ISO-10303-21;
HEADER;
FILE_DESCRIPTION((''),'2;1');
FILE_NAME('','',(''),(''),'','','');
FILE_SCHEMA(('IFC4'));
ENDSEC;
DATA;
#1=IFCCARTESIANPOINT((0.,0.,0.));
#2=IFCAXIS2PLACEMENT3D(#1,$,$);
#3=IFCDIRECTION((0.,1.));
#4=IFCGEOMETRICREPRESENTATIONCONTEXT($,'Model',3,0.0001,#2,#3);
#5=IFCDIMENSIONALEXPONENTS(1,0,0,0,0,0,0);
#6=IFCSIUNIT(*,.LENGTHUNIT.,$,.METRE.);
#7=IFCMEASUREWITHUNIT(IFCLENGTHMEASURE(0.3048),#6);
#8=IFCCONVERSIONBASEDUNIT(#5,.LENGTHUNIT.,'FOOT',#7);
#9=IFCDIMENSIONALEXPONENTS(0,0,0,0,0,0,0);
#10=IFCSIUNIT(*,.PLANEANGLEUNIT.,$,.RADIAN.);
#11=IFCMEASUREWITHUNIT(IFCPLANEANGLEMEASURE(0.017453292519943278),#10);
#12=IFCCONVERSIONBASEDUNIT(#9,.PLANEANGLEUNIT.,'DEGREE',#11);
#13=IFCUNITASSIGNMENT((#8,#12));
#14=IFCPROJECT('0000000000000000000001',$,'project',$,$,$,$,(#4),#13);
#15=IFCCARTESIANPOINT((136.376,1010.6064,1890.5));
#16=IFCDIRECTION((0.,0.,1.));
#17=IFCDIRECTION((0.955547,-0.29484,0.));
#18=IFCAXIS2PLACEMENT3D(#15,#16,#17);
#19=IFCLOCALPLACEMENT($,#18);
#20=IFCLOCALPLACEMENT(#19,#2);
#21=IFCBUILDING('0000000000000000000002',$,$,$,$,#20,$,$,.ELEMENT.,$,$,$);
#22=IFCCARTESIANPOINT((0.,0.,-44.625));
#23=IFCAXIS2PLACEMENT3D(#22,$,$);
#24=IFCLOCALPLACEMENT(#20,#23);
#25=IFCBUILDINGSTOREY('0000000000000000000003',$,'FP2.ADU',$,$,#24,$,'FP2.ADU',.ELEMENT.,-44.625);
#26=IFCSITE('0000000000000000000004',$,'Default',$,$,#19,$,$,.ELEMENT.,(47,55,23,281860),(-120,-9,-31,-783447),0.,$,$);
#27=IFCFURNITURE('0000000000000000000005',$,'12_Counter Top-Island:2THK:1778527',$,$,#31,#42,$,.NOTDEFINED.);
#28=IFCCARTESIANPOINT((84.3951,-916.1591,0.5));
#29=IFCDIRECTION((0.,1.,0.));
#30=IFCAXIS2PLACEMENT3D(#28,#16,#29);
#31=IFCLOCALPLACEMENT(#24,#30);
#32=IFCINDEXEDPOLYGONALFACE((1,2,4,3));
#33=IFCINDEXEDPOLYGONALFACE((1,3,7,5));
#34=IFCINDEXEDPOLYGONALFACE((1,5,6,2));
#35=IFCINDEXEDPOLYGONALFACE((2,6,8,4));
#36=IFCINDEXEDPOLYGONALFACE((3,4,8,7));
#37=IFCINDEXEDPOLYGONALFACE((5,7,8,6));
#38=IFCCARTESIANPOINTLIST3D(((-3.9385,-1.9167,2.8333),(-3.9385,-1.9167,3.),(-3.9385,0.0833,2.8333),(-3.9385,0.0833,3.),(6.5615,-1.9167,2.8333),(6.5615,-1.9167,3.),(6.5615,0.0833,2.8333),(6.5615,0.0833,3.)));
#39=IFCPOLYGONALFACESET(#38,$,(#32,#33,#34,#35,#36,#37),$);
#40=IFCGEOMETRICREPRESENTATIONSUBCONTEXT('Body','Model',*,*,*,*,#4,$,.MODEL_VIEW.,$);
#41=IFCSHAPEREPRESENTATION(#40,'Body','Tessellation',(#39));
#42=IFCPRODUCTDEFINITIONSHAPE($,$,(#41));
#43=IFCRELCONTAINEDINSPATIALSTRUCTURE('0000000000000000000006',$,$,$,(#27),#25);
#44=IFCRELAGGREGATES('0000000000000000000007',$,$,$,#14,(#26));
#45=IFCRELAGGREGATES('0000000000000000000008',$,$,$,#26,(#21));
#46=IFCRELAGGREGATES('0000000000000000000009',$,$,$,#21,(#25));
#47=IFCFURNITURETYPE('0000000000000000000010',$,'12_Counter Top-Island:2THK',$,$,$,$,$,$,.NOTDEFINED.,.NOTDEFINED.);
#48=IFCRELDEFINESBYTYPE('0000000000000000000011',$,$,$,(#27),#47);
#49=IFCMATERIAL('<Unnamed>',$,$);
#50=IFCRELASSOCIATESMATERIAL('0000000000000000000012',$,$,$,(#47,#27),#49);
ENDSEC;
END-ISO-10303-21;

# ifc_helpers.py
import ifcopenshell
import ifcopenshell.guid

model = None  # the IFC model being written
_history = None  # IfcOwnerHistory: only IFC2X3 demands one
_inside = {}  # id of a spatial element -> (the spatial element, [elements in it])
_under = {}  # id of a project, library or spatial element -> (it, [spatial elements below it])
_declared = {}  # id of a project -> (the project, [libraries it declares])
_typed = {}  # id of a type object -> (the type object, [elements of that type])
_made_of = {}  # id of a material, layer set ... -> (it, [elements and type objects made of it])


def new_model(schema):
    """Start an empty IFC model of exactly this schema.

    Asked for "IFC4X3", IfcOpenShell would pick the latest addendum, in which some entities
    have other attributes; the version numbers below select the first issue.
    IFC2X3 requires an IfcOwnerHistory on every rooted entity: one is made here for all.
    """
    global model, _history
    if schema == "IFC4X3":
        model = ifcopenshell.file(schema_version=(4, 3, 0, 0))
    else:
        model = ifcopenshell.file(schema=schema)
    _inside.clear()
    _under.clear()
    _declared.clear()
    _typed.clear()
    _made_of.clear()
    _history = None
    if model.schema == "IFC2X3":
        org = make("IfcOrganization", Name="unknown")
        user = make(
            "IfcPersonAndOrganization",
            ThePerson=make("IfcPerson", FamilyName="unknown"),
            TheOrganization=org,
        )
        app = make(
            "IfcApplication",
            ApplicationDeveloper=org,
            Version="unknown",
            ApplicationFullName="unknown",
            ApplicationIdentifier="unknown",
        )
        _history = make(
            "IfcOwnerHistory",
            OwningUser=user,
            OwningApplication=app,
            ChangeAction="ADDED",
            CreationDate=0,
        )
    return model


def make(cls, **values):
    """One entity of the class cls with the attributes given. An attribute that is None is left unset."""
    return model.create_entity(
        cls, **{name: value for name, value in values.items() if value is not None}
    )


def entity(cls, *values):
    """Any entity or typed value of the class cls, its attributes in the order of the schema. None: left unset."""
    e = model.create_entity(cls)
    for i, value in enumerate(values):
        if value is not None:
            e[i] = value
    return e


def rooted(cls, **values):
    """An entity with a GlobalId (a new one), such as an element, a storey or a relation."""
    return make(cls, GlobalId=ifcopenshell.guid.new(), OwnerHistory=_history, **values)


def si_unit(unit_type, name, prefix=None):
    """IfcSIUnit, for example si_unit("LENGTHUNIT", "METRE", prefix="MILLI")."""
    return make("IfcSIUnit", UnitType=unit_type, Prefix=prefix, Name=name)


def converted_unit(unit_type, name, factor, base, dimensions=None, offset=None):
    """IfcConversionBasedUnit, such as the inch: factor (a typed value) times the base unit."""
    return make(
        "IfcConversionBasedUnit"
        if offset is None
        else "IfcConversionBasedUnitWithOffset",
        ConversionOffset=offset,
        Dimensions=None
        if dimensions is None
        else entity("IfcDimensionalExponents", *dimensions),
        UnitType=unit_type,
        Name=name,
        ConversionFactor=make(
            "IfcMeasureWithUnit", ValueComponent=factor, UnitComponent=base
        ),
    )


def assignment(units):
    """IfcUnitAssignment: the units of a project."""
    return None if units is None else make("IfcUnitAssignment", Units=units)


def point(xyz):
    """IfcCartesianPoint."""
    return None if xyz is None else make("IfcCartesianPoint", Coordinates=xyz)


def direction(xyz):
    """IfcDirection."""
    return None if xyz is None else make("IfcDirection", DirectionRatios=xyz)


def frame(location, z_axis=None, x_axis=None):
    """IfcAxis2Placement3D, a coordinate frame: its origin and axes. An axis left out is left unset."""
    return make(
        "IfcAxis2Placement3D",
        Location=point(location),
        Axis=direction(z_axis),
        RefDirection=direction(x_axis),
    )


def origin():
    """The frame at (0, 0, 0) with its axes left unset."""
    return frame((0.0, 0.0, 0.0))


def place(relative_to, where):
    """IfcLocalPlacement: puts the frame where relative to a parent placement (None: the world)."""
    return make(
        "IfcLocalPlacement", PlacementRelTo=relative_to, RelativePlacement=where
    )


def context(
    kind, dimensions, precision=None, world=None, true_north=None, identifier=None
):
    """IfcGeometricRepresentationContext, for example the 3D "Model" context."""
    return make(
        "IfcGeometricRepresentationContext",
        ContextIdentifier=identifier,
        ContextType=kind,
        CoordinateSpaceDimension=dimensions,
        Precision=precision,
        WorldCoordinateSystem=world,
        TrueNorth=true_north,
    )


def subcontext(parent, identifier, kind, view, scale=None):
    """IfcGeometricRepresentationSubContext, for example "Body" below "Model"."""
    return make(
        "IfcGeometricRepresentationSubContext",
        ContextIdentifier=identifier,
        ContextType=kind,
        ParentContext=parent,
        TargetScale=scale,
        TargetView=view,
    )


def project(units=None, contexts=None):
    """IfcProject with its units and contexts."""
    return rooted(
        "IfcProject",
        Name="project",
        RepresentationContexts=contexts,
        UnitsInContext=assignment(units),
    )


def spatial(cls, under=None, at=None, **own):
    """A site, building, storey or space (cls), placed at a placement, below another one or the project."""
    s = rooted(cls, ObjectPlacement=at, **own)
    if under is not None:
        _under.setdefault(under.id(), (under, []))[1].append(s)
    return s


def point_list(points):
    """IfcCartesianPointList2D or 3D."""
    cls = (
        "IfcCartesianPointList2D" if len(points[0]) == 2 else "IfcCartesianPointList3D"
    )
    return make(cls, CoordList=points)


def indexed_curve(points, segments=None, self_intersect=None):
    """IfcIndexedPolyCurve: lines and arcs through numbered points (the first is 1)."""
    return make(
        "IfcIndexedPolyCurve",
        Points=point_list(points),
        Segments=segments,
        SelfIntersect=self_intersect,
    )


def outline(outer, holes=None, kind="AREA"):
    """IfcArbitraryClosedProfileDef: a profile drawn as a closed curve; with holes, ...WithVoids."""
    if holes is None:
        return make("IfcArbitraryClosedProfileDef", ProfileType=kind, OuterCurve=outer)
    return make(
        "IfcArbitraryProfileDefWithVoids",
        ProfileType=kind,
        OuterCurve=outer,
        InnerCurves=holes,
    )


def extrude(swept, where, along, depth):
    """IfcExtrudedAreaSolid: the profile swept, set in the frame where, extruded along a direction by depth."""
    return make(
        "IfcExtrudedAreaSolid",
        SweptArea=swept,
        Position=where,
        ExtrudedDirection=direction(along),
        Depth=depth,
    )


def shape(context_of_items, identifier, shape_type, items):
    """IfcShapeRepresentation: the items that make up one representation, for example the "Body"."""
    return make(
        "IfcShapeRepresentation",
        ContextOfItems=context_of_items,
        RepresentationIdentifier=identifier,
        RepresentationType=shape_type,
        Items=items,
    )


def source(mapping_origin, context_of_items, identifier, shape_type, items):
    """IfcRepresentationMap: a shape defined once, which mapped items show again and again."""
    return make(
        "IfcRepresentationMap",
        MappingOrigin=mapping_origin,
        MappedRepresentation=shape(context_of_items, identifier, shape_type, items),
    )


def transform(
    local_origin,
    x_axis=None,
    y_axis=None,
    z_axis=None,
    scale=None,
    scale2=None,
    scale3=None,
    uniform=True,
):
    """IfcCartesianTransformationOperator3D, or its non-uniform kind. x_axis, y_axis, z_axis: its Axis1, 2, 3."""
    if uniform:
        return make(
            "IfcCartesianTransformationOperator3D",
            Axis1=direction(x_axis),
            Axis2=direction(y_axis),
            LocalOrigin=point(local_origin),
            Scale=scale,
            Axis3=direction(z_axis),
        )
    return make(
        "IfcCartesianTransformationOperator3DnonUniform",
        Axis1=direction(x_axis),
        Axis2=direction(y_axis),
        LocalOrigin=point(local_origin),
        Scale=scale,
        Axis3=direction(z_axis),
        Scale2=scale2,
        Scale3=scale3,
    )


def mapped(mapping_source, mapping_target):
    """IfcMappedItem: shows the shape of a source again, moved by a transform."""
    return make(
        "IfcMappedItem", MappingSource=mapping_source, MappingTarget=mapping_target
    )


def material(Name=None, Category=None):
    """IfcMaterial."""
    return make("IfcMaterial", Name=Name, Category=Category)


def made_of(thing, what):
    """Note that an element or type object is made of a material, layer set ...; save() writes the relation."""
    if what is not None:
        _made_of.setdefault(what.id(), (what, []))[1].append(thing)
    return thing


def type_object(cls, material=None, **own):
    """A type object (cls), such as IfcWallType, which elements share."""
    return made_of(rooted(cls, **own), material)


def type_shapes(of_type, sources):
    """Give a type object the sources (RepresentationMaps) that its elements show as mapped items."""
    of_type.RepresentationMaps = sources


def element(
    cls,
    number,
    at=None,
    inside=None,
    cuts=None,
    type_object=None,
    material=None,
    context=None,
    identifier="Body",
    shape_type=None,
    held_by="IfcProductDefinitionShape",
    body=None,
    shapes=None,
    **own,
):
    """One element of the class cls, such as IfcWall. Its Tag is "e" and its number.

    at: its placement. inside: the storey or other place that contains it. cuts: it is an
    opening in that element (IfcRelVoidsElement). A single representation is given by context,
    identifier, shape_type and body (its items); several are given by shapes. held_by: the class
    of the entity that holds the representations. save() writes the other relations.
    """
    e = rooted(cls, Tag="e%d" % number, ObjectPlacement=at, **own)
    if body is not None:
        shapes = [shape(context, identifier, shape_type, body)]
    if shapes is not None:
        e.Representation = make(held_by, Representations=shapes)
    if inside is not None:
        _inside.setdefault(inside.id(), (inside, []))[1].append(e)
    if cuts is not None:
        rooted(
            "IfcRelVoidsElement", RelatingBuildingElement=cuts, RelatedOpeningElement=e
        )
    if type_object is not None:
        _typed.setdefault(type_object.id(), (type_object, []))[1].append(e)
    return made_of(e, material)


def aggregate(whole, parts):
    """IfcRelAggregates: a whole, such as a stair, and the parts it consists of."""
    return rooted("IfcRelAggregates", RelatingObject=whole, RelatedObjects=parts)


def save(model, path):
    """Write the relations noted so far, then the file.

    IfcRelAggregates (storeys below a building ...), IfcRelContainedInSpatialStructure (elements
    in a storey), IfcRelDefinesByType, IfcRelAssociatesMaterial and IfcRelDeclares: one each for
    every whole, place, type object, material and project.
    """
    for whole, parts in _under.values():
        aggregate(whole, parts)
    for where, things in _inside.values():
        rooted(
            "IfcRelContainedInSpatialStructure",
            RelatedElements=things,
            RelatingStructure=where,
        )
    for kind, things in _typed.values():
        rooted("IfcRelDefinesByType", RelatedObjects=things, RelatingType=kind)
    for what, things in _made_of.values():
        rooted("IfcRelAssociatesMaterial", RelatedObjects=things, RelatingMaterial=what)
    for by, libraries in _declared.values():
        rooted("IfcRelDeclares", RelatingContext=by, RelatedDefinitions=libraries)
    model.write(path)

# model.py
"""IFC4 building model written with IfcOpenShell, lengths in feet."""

from ifc_helpers import new_model, entity, si_unit, converted_unit, direction, frame, origin, place, context, subcontext, project, spatial, indexed_curve, outline, extrude, source, transform, mapped, material, type_object, type_shapes, element, save


model = new_model("IFC4")

# Units and contexts
model_context = context("Model", 3, precision=0.0001, world=origin(), true_north=direction((0.0, 1.0)))
body_context = subcontext(model_context, "Body", "Model", "MODEL_VIEW")
ifc_project = project(units=[converted_unit("LENGTHUNIT", "FOOT", entity("IfcLengthMeasure", 0.3048), si_unit("LENGTHUNIT", "METRE"), dimensions=[1, 0, 0, 0, 0, 0, 0]), converted_unit("PLANEANGLEUNIT", "DEGREE", entity("IfcPlaneAngleMeasure", 0.017453292519943278), si_unit("PLANEANGLEUNIT", "RADIAN"), dimensions=[0, 0, 0, 0, 0, 0, 0])], contexts=[model_context])

# Site, building, storey
site_placement = place(None, frame((136.376, 1010.6064, 1890.5), z_axis=(0.0, 0.0, 1.0), x_axis=(0.955547, -0.29484, 0.0)))
site = spatial("IfcSite", under=ifc_project, at=site_placement, Name="Default", CompositionType="ELEMENT", RefLatitude=(47, 55, 23, 281860), RefLongitude=(-120, -9, -31, -783447), RefElevation=0.0)
building_placement = place(site_placement, origin())
building = spatial("IfcBuilding", under=site, at=building_placement, CompositionType="ELEMENT")
storey_placement = place(building_placement, frame((0.0, 0.0, -44.625)))
storey = spatial("IfcBuildingStorey", under=building, at=storey_placement, Name="FP2.ADU", LongName="FP2.ADU", CompositionType="ELEMENT", Elevation=-44.625)

# Furniture
ifc_material_1 = material(Name="<Unnamed>")
furniture_type_1 = type_object("IfcFurnitureType", Name="12_Counter Top-Island:2THK", AssemblyPlace="NOTDEFINED", PredefinedType="NOTDEFINED", material=ifc_material_1)
shared_shape_1 = source(origin(), body_context, "Body", "SweptSolid", [
    extrude(outline(indexed_curve([(-5.25, -1.0), (5.25, -1.0), (5.25, 1.0), (-5.25, 1.0), (-5.25, -1.0)], self_intersect=False)), frame((1.3115, -0.9167, 2.8333), z_axis=(0.0, 0.0, 1.0), x_axis=(-1.0, 0.0, 0.0)), (0.0, 0.0, 1.0), 0.1667),
])
type_shapes(furniture_type_1, [shared_shape_1])
furniture_1_placement = place(storey_placement, frame((84.3951, -916.1591, 0.5), z_axis=(0.0, 0.0, 1.0), x_axis=(0.0, 1.0, 0.0)))
element("IfcFurniture", 1, at=furniture_1_placement, inside=storey, type_object=furniture_type_1, material=ifc_material_1, Name="12_Counter Top-Island:2THK:1778527", PredefinedType="NOTDEFINED", context=body_context, shape_type="MappedRepresentation", body=[
    mapped(shared_shape_1, transform((0.0, 0.0, 0.0), scale=1.0)),
])

save(model, "model.ifc")
